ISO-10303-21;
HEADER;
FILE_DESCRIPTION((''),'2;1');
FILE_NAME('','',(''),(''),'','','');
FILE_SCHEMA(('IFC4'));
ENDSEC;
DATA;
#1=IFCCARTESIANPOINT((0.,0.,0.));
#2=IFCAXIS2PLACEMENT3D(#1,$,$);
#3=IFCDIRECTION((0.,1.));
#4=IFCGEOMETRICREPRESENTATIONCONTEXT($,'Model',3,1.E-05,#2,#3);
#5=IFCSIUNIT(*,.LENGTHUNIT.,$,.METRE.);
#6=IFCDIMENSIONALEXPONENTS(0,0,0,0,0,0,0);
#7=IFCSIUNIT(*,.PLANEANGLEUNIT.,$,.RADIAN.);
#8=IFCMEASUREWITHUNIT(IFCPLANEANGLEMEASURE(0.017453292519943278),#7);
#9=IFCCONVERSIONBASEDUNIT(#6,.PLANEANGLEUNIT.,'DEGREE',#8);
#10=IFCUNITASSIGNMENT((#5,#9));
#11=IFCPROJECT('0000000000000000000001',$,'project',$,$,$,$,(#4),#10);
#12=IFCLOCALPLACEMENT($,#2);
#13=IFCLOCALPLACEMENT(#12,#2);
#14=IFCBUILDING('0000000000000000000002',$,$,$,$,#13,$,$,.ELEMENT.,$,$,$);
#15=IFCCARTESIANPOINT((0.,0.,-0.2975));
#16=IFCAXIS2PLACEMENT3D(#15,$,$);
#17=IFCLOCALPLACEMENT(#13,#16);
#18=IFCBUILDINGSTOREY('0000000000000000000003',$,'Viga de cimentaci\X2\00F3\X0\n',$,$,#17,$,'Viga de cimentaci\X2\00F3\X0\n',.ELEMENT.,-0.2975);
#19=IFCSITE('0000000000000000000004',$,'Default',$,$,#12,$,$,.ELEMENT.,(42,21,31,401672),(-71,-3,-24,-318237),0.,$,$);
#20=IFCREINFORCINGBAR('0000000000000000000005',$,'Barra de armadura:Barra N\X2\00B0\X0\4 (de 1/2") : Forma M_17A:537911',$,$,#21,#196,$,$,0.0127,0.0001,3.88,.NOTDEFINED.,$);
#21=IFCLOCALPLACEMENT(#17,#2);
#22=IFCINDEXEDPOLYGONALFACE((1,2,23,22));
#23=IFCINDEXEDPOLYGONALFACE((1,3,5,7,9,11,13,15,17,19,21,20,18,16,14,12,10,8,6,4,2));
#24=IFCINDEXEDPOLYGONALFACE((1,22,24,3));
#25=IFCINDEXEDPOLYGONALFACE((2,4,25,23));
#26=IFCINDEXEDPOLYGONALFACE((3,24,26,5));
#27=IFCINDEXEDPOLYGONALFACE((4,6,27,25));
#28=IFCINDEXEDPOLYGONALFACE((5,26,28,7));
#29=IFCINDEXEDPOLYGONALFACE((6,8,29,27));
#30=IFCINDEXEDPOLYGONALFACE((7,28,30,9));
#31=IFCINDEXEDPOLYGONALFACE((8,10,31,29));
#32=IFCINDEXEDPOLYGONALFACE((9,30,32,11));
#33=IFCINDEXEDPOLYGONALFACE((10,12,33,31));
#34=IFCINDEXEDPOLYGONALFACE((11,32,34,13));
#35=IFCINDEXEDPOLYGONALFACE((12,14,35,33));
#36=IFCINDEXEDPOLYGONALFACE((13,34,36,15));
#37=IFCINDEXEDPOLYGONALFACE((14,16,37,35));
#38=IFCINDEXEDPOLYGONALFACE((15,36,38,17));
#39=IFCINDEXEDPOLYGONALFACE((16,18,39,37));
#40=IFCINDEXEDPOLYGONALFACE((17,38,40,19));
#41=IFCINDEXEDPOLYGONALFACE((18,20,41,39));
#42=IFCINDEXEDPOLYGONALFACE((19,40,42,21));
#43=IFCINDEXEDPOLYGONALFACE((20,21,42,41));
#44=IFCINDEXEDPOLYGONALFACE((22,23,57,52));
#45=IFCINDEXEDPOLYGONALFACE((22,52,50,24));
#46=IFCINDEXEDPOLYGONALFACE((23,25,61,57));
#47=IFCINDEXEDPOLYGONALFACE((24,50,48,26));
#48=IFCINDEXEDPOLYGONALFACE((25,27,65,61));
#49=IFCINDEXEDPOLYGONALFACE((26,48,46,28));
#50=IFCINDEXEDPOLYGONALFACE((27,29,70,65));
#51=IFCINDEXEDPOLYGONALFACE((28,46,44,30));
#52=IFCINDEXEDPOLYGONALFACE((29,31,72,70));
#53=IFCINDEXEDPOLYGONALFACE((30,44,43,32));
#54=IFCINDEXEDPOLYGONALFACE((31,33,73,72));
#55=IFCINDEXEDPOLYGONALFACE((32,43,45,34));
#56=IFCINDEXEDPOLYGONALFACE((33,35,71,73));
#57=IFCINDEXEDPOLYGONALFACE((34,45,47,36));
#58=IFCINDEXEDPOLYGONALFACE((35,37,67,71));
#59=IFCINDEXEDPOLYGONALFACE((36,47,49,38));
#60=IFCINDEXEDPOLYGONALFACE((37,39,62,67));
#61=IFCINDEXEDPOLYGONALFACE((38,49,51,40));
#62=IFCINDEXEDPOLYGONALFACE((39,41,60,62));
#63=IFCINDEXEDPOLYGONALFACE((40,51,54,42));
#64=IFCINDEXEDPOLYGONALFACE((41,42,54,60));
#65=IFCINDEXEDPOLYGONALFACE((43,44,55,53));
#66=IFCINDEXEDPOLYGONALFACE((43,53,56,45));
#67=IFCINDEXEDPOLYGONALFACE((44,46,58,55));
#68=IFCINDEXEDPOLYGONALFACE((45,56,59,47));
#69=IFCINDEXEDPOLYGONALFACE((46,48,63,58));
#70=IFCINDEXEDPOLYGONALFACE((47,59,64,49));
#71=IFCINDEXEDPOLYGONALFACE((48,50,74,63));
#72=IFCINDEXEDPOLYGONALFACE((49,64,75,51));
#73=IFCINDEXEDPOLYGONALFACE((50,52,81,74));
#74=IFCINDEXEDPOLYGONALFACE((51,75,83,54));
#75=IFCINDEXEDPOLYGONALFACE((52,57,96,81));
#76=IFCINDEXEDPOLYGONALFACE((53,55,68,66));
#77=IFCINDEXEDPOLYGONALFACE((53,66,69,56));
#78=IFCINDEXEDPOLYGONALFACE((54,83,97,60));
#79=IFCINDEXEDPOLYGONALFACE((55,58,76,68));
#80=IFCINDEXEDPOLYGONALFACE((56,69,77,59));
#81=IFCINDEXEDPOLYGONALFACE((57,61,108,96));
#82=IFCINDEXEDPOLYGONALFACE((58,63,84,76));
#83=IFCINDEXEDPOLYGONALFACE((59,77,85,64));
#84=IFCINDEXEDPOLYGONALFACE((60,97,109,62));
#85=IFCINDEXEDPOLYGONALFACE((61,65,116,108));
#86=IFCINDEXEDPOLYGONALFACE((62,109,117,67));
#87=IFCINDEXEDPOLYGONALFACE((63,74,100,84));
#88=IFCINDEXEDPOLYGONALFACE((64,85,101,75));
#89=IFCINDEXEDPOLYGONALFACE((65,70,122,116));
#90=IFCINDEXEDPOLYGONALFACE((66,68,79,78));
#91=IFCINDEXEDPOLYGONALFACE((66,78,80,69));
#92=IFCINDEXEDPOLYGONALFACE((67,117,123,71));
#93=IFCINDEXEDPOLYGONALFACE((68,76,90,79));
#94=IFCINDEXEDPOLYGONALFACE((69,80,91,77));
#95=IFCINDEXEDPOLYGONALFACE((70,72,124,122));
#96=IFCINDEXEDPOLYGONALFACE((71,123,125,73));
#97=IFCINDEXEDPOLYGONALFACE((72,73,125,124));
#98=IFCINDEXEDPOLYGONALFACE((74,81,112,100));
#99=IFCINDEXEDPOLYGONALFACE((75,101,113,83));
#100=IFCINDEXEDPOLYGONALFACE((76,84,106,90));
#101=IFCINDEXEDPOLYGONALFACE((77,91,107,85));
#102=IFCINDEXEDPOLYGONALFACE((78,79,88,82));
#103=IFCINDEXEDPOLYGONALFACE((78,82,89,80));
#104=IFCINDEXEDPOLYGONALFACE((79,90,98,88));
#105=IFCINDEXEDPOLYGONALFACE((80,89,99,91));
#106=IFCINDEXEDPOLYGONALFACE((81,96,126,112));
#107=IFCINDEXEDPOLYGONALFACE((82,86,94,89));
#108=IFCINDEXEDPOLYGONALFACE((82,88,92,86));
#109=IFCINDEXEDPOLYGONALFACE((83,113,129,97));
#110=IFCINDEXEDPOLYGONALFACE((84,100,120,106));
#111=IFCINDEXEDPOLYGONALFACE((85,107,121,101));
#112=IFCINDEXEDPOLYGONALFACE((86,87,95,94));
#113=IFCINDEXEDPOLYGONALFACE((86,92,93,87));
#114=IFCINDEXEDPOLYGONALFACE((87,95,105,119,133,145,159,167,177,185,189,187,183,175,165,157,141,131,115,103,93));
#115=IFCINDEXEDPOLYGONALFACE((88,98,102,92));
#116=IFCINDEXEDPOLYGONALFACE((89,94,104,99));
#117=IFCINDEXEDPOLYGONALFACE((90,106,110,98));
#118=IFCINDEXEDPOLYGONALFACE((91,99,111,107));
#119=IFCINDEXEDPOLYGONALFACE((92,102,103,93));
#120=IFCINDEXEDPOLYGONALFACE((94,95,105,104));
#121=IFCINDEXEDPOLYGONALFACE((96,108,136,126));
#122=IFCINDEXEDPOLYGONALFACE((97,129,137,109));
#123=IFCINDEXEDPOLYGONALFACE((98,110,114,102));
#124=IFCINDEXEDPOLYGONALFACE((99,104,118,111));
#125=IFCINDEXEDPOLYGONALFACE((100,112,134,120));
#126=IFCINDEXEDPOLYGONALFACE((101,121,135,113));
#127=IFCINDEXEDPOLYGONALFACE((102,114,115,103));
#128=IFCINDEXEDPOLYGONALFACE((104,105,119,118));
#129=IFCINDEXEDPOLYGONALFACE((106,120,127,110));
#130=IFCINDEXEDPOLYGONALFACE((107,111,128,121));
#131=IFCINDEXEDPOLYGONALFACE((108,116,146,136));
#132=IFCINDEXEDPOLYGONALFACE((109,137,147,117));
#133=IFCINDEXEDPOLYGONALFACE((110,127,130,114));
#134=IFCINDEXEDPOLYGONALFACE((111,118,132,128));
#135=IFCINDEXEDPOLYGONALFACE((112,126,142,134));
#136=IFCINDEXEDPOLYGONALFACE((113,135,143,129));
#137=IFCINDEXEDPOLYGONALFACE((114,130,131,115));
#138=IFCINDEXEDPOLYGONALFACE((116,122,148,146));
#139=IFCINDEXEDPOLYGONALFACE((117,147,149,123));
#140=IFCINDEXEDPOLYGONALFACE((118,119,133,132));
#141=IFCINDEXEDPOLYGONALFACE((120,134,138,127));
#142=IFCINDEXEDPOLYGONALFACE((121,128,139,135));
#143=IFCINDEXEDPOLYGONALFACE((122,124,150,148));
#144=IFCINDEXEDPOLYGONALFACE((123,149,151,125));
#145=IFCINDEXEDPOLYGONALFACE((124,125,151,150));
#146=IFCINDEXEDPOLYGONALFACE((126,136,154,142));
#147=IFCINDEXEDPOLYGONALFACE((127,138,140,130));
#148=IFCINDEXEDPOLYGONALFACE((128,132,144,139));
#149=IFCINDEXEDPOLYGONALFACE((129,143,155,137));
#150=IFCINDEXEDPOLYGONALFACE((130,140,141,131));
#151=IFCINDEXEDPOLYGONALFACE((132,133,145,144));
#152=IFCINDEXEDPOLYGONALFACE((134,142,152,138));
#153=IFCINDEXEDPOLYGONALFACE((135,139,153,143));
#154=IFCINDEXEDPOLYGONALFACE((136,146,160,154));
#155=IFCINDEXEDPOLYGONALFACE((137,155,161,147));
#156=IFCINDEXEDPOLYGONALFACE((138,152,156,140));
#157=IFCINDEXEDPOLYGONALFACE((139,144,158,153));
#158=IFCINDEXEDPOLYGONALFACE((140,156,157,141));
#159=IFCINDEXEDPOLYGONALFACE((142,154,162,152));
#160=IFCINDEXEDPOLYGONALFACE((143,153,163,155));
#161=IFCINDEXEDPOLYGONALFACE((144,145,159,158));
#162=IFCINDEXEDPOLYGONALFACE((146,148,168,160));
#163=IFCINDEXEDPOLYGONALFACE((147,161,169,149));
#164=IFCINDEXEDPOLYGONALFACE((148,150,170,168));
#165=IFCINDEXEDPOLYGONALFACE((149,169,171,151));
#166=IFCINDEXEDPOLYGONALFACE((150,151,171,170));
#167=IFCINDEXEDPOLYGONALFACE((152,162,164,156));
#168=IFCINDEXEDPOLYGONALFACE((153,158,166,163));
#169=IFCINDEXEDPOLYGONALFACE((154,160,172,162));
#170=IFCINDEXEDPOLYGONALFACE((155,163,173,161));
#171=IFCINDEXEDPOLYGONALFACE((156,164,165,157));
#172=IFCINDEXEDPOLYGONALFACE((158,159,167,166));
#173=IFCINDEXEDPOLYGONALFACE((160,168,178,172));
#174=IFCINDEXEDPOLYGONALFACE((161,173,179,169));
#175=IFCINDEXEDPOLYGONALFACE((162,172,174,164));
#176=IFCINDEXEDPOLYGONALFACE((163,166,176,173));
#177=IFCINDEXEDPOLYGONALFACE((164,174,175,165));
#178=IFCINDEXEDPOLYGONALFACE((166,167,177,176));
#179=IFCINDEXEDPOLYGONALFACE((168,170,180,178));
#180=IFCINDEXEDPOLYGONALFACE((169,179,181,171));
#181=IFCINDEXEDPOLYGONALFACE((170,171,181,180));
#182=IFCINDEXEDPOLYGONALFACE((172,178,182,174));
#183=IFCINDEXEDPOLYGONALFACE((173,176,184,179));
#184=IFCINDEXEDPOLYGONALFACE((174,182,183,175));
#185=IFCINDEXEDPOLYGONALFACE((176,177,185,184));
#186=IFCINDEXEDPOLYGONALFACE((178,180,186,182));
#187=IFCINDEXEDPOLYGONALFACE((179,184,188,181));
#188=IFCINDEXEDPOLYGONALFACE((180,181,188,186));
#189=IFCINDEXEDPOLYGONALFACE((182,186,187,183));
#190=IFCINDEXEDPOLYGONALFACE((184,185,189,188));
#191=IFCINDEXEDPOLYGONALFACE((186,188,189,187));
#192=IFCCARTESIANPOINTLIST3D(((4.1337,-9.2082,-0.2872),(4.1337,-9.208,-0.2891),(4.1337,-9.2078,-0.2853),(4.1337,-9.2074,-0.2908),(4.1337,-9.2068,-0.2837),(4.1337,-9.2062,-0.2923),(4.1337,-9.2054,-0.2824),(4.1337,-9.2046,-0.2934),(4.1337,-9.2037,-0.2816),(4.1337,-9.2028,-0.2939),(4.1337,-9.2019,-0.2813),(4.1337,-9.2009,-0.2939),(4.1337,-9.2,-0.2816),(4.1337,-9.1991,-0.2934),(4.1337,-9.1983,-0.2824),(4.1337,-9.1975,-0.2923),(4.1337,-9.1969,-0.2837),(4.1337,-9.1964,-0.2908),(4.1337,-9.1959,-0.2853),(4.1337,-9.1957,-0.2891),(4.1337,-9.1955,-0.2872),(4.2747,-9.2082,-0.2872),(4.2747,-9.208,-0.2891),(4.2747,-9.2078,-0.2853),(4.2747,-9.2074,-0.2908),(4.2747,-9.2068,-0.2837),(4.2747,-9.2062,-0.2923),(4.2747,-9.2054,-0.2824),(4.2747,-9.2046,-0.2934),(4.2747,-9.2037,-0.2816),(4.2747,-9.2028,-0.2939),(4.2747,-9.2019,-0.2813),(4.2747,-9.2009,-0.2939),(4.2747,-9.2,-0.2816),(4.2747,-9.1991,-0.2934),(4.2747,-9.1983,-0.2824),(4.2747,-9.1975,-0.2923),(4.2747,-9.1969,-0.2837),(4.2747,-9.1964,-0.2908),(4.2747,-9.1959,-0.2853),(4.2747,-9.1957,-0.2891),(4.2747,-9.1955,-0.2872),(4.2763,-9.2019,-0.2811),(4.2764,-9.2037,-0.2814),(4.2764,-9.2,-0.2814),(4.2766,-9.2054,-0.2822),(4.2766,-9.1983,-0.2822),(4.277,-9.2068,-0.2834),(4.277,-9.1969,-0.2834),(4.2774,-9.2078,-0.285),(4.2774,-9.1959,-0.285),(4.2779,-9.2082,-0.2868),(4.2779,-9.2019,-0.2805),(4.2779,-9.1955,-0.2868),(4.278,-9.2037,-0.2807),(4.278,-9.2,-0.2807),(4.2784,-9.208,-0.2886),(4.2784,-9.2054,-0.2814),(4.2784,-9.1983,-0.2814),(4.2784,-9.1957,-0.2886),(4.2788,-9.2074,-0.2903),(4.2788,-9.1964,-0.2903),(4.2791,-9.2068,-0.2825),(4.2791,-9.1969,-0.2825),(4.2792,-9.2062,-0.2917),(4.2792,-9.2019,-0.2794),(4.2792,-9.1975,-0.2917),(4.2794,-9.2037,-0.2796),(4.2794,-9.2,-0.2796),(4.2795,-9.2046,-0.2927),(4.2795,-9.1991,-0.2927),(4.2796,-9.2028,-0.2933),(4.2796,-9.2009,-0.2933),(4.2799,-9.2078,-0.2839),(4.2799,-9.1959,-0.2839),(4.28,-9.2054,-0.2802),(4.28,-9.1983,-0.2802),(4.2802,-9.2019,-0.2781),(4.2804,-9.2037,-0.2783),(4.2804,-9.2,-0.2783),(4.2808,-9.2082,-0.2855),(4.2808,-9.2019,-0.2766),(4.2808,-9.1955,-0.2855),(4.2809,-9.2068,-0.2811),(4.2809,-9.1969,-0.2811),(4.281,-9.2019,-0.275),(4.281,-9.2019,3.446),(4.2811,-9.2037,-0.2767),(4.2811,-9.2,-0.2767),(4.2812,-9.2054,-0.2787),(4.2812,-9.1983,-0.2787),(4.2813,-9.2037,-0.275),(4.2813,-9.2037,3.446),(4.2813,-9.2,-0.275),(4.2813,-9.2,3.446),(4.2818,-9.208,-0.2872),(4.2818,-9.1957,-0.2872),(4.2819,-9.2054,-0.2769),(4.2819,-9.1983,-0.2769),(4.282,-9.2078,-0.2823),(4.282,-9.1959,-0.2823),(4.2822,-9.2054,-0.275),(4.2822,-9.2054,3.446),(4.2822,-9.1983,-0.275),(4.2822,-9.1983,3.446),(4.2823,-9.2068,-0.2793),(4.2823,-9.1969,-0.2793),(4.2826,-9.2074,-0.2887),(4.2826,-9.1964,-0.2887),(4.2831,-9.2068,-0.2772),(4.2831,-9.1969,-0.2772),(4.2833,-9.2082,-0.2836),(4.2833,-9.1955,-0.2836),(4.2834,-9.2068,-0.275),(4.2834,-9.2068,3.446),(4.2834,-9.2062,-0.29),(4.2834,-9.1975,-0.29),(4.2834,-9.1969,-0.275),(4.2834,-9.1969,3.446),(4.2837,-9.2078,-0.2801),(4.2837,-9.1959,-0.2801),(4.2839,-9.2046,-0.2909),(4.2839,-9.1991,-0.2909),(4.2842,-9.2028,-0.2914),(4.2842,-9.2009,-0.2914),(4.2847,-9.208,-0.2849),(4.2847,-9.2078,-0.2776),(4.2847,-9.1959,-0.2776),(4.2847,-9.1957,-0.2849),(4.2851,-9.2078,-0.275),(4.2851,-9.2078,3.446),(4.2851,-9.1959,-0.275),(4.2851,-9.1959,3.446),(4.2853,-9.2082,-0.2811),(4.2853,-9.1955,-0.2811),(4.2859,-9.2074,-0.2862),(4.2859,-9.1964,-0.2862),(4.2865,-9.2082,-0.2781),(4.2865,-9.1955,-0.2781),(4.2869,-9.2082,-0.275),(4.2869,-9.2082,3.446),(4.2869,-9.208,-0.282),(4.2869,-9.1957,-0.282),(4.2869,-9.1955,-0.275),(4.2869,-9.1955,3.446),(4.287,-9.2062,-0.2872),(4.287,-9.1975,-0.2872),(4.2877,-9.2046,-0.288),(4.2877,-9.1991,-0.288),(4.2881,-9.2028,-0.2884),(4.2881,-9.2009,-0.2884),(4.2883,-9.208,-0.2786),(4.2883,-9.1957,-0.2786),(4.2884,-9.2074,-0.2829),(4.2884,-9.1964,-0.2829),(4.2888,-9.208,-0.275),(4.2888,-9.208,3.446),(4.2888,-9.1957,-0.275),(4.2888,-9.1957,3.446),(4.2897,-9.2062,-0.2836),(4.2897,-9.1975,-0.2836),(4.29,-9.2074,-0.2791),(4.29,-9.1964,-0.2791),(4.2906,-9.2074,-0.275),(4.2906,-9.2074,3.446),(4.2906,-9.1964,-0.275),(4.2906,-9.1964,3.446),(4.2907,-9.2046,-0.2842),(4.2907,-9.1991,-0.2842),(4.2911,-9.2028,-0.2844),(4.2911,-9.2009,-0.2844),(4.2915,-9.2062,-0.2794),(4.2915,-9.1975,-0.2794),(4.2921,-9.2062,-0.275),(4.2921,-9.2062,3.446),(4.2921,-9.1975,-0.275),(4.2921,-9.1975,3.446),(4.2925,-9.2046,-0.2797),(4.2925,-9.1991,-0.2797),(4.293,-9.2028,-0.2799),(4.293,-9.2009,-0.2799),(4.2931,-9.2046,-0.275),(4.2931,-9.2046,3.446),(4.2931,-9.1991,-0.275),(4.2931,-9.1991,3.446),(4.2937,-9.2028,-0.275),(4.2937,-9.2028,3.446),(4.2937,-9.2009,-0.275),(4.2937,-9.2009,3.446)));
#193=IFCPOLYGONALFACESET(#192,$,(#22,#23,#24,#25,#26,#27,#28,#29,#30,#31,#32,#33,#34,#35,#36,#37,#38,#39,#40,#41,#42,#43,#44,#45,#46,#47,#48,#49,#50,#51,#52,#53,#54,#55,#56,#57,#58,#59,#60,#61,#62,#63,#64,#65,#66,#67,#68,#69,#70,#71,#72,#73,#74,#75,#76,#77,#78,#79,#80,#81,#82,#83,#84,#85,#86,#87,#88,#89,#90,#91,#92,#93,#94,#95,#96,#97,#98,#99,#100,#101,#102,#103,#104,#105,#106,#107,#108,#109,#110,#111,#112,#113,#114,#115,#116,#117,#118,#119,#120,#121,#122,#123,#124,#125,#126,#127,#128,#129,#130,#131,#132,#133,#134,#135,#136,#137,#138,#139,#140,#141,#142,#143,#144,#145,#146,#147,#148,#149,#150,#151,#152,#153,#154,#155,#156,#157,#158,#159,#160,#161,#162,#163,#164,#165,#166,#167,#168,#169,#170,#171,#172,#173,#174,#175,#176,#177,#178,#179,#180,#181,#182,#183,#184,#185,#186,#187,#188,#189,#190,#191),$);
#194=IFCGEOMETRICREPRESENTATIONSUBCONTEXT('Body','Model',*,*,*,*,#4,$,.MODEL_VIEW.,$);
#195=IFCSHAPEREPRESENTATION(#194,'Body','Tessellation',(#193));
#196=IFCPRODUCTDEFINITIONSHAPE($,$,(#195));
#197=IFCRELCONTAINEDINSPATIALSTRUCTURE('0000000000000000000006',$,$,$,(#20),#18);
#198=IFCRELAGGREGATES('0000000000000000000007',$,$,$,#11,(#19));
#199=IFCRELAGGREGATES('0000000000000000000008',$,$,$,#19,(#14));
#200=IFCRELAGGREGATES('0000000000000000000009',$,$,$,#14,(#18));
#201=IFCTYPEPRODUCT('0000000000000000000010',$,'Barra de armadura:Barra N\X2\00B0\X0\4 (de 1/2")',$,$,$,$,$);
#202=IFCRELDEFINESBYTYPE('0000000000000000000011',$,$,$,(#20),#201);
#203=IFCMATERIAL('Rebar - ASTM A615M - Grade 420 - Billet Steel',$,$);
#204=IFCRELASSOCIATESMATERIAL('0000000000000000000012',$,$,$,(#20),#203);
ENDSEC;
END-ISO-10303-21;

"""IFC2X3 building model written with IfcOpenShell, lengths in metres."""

from ifc_helpers import new_model, entity, si_unit, converted_unit, direction, frame, origin, place, context, subcontext, project, spatial, material, type_object, element, save


model = new_model("IFC2X3")

# Units and contexts
model_context = context("Model", 3, precision=1e-05, world=origin(), true_north=direction((0.0, 1.0)))
body_context = subcontext(model_context, "Body", "Model", "MODEL_VIEW")
ifc_project = project(units=[si_unit("LENGTHUNIT", "METRE"), converted_unit("PLANEANGLEUNIT", "DEGREE", entity("IfcPlaneAngleMeasure", 0.017453292519943278), si_unit("PLANEANGLEUNIT", "RADIAN"), dimensions=[0, 0, 0, 0, 0, 0, 0])], contexts=[model_context])

# Site, building, storey
site_placement = place(None, origin())
site = spatial("IfcSite", under=ifc_project, at=site_placement, Name="Default", CompositionType="ELEMENT", RefLatitude=(42, 21, 31, 401672), RefLongitude=(-71, -3, -24, -318237), RefElevation=0.0)
building_placement = place(site_placement, origin())
building = spatial("IfcBuilding", under=site, at=building_placement, CompositionType="ELEMENT")
storey_placement = place(building_placement, frame((0.0, 0.0, -0.2975)))
storey = spatial("IfcBuildingStorey", under=building, at=storey_placement, Name="Viga de cimentación", LongName="Viga de cimentación", CompositionType="ELEMENT", Elevation=-0.2975)

# Reinforcing bar
ifc_material_1 = material(Name="Rebar - ASTM A615M - Grade 420 - Billet Steel")
type_product_1 = type_object("IfcTypeProduct", Name="Barra de armadura:Barra N°4 (de 1/2\")")
reinforcing_bar_1_placement = place(storey_placement, origin())
element("IfcReinforcingBar", 1, at=reinforcing_bar_1_placement, inside=storey, type_object=type_product_1, material=ifc_material_1, Name="Barra de armadura:Barra N°4 (de 1/2\") : Forma M_17A:537911", BarLength=3.88, BarRole="NOTDEFINED", CrossSectionArea=0.0001, NominalDiameter=0.0127, context=body_context, shape_type="AdvancedSweptSolid", body=[
    entity("IfcSweptDiskSolid", entity("IfcCompositeCurve", [entity("IfcCompositeCurveSegment", "CONTINUOUS", True, entity("IfcPolyline", [entity("IfcCartesianPoint", [4.2874, -9.2019, 3.446]), entity("IfcCartesianPoint", [4.2874, -9.2019, -0.275])])), entity("IfcCompositeCurveSegment", "CONTINUOUS", True, entity("IfcTrimmedCurve", entity("IfcCircle", entity("IfcAxis2Placement3D", entity("IfcCartesianPoint", [4.2747, -9.2019, -0.275]), entity("IfcDirection", [0.0, 1.0, 0.0]), entity("IfcDirection", [0.0, 0.0, -1.0])), 0.0127), [entity("IfcParameterValue", 270.0)], [entity("IfcParameterValue", 360.0)], True, "PARAMETER")), entity("IfcCompositeCurveSegment", "CONTINUOUS", True, entity("IfcPolyline", [entity("IfcCartesianPoint", [4.2747, -9.2019, -0.2877]), entity("IfcCartesianPoint", [4.1337, -9.2019, -0.2877])]))], False), 0.0063, None, 0.0, 92.0),
])

save(model, "model.ifc")
